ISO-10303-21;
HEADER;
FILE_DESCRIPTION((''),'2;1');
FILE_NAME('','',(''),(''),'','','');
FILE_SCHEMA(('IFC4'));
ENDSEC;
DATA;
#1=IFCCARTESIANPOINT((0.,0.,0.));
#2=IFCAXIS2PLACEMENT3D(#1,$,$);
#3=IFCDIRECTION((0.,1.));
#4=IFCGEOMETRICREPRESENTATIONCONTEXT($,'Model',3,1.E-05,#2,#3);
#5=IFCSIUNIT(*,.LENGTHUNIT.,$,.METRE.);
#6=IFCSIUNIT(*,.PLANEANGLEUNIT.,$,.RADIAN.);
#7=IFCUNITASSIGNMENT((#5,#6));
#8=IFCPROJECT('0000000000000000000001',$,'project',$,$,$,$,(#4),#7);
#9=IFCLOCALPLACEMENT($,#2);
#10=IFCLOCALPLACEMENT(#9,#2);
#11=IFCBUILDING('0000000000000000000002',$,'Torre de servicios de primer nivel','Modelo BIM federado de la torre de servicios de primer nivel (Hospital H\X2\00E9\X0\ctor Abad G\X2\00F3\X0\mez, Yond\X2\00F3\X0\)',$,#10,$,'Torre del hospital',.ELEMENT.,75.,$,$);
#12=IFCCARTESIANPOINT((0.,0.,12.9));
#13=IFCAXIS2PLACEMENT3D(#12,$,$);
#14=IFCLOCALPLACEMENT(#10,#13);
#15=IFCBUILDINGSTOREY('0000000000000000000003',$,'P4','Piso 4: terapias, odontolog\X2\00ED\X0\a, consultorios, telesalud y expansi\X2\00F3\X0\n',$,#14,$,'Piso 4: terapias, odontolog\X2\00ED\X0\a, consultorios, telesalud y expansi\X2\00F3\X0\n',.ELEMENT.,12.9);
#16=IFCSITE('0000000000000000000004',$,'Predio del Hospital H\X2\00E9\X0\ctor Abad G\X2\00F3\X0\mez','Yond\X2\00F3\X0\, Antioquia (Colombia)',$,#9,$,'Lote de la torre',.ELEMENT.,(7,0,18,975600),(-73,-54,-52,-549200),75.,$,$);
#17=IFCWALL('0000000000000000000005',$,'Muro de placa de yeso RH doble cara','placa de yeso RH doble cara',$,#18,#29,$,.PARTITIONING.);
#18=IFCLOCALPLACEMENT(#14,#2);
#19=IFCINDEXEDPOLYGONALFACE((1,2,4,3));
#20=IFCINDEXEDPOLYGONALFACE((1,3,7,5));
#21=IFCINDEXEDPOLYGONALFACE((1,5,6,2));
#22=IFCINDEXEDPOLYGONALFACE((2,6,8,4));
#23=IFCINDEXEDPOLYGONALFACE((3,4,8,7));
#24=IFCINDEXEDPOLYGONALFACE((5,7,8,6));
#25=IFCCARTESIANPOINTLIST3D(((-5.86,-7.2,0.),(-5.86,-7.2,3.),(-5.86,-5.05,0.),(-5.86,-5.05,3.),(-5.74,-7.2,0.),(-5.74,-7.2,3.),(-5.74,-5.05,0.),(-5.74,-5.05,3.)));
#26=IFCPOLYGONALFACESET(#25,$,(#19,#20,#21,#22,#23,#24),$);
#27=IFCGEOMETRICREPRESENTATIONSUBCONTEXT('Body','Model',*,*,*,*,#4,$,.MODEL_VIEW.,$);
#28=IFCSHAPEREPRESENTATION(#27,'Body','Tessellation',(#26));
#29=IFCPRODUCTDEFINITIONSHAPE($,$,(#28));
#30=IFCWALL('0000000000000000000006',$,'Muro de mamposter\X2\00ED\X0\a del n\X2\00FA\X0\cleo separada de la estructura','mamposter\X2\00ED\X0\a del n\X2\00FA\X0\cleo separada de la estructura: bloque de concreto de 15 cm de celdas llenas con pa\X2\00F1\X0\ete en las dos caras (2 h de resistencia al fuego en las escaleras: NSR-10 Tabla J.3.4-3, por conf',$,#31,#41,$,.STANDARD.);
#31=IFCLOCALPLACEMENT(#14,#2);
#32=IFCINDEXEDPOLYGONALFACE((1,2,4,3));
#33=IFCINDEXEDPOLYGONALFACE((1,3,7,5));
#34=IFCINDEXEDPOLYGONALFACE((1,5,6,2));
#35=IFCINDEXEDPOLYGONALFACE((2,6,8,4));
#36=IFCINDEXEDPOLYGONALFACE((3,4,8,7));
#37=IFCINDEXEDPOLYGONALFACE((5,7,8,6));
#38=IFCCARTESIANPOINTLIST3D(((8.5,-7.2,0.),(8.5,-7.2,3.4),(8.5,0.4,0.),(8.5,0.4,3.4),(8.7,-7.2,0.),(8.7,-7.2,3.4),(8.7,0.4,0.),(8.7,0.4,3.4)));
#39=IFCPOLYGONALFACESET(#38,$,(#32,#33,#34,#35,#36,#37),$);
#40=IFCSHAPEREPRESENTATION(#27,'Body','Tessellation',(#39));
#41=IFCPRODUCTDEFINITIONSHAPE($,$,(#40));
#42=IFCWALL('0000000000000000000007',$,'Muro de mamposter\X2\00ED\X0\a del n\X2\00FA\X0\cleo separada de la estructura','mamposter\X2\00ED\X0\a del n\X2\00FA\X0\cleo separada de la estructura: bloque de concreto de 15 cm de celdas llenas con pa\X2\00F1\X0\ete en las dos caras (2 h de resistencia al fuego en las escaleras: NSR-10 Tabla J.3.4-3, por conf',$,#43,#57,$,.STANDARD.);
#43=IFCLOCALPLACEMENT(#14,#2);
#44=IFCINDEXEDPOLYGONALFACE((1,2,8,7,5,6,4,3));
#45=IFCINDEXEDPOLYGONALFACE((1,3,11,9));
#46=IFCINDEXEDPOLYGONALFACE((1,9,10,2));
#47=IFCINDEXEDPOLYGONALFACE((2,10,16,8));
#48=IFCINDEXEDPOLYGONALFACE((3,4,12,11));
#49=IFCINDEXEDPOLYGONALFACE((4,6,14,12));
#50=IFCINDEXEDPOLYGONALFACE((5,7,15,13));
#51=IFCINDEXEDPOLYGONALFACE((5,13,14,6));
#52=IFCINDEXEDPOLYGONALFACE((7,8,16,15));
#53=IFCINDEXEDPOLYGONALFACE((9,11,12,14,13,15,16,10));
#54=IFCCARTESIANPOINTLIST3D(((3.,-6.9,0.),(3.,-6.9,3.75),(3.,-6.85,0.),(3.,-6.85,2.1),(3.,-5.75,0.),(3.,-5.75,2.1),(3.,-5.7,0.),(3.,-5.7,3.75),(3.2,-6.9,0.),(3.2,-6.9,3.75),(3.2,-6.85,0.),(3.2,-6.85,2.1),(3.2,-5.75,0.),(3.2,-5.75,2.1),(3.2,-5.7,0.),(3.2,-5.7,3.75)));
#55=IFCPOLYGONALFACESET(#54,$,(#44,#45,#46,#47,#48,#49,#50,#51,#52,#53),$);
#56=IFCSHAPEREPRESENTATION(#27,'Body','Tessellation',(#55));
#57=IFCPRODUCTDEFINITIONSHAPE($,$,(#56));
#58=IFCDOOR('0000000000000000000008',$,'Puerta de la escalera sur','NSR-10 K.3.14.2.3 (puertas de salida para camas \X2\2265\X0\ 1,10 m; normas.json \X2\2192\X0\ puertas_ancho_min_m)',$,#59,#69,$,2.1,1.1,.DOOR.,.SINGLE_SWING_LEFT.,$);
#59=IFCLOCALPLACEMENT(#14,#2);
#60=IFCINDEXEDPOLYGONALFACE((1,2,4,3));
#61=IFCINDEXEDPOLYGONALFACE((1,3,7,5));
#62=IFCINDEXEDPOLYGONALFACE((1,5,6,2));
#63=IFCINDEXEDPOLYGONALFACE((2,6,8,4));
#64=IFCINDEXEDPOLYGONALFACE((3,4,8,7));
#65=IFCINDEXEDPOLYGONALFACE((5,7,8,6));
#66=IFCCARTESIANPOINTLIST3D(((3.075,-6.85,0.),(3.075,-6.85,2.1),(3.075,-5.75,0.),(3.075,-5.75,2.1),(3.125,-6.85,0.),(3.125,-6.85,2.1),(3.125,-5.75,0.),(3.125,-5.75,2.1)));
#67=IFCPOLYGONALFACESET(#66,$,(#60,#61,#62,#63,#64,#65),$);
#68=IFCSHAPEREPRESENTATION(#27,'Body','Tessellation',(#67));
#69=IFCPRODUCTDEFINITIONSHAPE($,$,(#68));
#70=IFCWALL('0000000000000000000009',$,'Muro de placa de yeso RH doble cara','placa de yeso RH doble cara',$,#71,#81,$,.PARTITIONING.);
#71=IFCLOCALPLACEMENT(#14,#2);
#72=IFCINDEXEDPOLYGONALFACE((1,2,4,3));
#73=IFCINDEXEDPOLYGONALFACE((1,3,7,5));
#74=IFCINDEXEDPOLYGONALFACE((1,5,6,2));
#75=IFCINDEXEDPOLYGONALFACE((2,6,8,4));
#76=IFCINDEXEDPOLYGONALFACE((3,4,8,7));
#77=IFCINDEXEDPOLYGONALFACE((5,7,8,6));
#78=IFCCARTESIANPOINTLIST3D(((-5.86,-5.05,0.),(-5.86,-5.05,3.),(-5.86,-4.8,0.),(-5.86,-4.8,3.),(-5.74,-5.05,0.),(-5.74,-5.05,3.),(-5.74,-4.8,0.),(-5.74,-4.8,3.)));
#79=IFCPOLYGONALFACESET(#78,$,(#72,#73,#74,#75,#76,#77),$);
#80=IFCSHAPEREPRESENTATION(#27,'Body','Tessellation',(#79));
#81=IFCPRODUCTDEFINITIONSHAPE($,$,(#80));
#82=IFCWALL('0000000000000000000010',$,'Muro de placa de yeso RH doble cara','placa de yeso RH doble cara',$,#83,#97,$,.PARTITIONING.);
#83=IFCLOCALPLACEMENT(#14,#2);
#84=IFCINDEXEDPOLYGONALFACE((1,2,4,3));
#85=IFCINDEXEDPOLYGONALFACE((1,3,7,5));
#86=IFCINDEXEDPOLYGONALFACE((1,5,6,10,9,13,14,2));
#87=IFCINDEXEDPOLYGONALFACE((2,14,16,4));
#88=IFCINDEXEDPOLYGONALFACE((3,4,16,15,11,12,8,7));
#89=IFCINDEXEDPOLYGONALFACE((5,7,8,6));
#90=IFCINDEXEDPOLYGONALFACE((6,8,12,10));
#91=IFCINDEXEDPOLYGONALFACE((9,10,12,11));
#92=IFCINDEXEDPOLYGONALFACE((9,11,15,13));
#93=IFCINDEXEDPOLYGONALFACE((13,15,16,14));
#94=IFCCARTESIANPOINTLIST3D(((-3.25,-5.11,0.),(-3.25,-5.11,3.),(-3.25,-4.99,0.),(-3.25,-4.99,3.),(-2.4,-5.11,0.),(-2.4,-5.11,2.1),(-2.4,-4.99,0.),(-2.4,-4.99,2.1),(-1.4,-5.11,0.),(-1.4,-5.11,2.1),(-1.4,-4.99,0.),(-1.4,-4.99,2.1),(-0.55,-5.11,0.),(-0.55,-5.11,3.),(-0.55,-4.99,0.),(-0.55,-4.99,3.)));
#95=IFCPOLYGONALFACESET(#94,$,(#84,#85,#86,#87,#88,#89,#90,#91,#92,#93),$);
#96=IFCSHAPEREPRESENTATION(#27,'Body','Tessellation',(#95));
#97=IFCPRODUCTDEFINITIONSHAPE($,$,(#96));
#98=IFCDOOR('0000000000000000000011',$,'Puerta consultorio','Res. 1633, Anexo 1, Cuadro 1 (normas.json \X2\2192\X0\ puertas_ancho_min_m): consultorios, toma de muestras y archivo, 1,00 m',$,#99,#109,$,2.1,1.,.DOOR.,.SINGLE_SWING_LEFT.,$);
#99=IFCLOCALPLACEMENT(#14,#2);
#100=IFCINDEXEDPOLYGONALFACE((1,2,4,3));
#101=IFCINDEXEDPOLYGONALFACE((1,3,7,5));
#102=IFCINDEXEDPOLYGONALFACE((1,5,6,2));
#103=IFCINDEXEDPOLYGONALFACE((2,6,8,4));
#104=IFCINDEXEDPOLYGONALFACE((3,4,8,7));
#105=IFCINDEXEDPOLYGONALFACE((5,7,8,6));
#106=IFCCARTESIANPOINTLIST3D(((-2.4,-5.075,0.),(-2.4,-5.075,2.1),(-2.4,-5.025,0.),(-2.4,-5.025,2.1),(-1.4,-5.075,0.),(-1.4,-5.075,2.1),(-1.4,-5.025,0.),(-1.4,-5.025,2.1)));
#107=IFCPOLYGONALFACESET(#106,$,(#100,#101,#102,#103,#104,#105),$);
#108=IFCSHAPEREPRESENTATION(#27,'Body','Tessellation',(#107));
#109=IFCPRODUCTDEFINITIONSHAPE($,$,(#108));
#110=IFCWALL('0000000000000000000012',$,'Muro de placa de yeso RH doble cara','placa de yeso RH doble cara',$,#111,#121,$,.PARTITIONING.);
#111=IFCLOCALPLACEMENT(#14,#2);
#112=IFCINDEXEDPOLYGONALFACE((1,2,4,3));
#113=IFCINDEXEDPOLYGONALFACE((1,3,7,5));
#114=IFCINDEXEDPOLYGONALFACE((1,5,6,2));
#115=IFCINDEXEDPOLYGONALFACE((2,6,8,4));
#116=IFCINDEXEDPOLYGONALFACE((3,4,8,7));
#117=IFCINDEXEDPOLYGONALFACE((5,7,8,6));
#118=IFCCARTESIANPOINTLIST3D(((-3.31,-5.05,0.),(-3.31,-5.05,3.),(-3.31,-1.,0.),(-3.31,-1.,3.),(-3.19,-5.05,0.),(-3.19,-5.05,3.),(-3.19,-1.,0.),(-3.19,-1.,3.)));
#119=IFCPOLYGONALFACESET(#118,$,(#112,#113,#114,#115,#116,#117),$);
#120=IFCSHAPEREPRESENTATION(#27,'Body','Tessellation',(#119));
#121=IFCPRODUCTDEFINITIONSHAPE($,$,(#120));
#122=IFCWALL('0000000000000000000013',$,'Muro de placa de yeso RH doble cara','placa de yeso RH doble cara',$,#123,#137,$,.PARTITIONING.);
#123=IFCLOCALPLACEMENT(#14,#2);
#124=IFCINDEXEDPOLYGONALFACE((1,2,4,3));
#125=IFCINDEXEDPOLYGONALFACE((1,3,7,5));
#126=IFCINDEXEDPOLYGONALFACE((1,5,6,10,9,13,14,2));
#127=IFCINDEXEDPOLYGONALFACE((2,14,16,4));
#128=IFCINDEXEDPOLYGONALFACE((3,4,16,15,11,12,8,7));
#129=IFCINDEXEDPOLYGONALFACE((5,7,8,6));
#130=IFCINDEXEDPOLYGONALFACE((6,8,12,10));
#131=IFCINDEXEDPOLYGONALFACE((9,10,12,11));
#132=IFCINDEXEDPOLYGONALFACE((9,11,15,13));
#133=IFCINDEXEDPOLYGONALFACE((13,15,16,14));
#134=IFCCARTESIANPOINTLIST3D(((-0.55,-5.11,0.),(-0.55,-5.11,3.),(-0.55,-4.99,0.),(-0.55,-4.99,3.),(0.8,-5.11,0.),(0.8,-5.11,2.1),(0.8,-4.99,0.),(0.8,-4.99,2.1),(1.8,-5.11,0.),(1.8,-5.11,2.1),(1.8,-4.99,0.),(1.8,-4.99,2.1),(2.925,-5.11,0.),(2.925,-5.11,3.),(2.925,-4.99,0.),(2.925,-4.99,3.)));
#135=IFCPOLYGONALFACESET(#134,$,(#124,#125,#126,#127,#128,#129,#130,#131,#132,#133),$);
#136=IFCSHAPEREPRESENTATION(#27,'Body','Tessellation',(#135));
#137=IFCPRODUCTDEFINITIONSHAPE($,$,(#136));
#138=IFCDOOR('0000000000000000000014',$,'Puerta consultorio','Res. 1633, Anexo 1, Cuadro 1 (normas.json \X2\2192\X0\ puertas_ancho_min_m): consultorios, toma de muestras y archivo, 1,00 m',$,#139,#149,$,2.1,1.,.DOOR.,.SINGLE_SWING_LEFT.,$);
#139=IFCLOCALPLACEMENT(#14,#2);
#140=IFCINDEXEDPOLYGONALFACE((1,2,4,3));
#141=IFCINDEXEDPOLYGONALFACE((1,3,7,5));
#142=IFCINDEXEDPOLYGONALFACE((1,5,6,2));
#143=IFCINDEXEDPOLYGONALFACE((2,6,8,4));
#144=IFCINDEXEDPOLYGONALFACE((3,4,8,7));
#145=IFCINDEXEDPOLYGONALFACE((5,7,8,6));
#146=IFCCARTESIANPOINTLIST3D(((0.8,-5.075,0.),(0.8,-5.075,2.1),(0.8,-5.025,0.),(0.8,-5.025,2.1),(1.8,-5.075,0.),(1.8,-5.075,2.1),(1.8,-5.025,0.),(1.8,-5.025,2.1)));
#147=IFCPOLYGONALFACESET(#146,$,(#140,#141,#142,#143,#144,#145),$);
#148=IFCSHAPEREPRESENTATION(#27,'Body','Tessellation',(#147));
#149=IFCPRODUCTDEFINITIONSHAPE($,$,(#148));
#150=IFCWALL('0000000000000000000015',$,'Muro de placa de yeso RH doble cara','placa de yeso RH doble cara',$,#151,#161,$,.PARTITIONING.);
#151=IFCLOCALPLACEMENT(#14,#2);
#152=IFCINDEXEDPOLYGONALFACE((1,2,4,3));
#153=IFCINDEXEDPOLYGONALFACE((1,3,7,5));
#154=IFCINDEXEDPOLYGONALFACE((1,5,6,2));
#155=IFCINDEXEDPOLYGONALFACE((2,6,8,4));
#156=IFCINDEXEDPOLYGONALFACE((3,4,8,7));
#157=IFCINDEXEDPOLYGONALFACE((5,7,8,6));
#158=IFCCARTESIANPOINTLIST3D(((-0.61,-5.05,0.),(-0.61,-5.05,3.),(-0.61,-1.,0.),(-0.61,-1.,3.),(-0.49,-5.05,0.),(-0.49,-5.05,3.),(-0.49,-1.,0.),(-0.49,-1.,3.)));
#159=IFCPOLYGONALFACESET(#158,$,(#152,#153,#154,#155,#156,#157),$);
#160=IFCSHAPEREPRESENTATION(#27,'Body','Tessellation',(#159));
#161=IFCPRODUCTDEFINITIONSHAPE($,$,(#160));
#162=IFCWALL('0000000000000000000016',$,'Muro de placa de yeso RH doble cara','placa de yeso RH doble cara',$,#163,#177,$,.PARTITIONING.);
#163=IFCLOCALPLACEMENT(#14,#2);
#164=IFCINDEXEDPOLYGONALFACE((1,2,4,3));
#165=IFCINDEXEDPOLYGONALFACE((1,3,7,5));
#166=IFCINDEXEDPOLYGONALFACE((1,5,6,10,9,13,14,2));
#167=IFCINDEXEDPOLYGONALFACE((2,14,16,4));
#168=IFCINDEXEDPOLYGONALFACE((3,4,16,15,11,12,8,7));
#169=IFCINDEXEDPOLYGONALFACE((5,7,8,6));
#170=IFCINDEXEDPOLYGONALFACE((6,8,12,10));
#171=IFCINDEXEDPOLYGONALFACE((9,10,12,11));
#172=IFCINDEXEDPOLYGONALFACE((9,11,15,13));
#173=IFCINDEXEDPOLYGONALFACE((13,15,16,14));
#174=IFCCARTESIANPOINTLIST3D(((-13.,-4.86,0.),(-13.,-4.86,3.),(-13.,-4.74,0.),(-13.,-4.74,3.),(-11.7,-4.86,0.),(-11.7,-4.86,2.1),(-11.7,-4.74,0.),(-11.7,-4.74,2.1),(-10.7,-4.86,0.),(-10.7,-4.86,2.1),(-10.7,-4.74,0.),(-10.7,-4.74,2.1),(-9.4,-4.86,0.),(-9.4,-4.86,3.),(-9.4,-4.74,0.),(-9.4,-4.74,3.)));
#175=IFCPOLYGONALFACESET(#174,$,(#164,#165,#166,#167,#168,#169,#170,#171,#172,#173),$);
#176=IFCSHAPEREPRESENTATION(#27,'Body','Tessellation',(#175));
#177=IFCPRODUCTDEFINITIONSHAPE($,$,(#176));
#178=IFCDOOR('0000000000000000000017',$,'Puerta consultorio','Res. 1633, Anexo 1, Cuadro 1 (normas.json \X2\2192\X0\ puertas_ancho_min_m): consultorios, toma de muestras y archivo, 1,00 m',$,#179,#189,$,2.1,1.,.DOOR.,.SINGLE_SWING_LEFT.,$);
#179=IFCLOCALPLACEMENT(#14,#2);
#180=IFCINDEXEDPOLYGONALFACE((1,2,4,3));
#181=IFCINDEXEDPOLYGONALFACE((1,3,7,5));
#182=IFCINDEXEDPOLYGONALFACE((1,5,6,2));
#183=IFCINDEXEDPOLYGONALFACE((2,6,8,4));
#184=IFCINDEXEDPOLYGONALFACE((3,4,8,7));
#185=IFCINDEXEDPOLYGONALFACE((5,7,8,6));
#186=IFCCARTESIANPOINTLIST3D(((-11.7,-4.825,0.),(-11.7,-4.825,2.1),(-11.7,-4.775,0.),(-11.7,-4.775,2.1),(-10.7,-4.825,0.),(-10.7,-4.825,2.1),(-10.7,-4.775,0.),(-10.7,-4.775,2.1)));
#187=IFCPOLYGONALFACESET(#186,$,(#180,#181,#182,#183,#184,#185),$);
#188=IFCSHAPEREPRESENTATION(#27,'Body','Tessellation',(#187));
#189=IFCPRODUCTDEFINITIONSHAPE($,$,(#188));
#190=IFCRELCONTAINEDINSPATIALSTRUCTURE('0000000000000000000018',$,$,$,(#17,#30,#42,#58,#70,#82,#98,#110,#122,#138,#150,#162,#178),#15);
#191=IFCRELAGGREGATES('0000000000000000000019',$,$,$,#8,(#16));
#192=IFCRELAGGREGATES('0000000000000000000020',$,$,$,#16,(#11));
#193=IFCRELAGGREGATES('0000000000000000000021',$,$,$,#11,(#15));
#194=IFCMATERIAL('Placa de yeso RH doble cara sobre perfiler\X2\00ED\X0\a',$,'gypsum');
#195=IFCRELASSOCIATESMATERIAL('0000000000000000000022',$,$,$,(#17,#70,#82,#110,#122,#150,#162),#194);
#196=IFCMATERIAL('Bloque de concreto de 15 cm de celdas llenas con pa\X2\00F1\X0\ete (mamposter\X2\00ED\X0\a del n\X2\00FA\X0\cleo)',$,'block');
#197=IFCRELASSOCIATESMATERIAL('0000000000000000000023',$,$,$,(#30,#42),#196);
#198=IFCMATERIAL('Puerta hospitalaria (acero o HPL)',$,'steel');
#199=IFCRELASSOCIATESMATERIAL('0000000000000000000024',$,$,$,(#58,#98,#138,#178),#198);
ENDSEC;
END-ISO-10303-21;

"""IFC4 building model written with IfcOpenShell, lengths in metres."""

from ifc_helpers import new_model, si_unit, direction, frame, origin, place, context, subcontext, project, spatial, rectangle, extrude, material, element, fill, save


model = new_model("IFC4")

# Units and contexts
model_context = context("Model", 3, precision=1e-05, world=origin(), true_north=direction((0.0, 1.0)))
body_context = subcontext(model_context, "Body", "Model", "MODEL_VIEW")
ifc_project = project(units=[si_unit("LENGTHUNIT", "METRE"), si_unit("PLANEANGLEUNIT", "RADIAN")], contexts=[model_context])

# Site, building, storey
site_placement = place(None, origin())
site = spatial("IfcSite", under=ifc_project, at=site_placement, Name="Predio del Hospital Héctor Abad Gómez", Description="Yondó, Antioquia (Colombia)", LongName="Lote de la torre", CompositionType="ELEMENT", RefLatitude=(7, 0, 18, 975600), RefLongitude=(-73, -54, -52, -549200), RefElevation=75.0)
building_placement = place(site_placement, origin())
building = spatial("IfcBuilding", under=site, at=building_placement, Name="Torre de servicios de primer nivel", Description="Modelo BIM federado de la torre de servicios de primer nivel (Hospital Héctor Abad Gómez, Yondó)", LongName="Torre del hospital", CompositionType="ELEMENT", ElevationOfRefHeight=75.0)
placement = place(building_placement, frame((0.0, 0.0, 12.9)))
storey = spatial("IfcBuildingStorey", under=building, at=placement, Name="P4", Description="Piso 4: terapias, odontología, consultorios, telesalud y expansión", LongName="Piso 4: terapias, odontología, consultorios, telesalud y expansión", CompositionType="ELEMENT", Elevation=12.9)

# Walls
ifc_material_1 = material(Name="Placa de yeso RH doble cara sobre perfilería", Category="gypsum")
element("IfcWall", 1, at=placement, inside=storey, material=ifc_material_1, Name="Muro de placa de yeso RH doble cara", Description="placa de yeso RH doble cara", PredefinedType="PARTITIONING", context=body_context, shape_type="SweptSolid", body=[
    extrude(rectangle(XDim=0.12, YDim=2.15), frame((-5.8, -6.125, 0.0)), (0.0, 0.0, 1.0), 3.0),
])
ifc_material_2 = material(Name="Bloque de concreto de 15 cm de celdas llenas con pañete (mampostería del núcleo)", Category="block")
element("IfcWall", 2, at=placement, inside=storey, material=ifc_material_2, Name="Muro de mampostería del núcleo separada de la estructura", Description="mampostería del núcleo separada de la estructura: bloque de concreto de 15 cm de celdas llenas con pañete en las dos caras (2 h de resistencia al fuego en las escaleras: NSR-10 Tabla J.3.4-3, por conf", PredefinedType="STANDARD", context=body_context, shape_type="SweptSolid", body=[
    extrude(rectangle(XDim=0.2, YDim=7.6), frame((8.6, -3.4, 0.0)), (0.0, 0.0, 1.0), 3.4),
])

# Wall, opening, door
wall_1 = element("IfcWall", 3, at=placement, inside=storey, material=ifc_material_2, Name="Muro de mampostería del núcleo separada de la estructura", Description="mampostería del núcleo separada de la estructura: bloque de concreto de 15 cm de celdas llenas con pañete en las dos caras (2 h de resistencia al fuego en las escaleras: NSR-10 Tabla J.3.4-3, por conf", PredefinedType="STANDARD", context=body_context, shape_type="SweptSolid", body=[
    extrude(rectangle(XDim=0.2, YDim=1.2), frame((3.1, -6.3, 0.0)), (0.0, 0.0, 1.0), 3.75),
])
opening_1 = element("IfcOpeningElement", 4, at=placement, cuts=wall_1, PredefinedType="OPENING", context=body_context, shape_type="SweptSolid", body=[
    extrude(rectangle(XDim=0.3, YDim=1.1), frame((3.1, -6.3, 0.0)), (0.0, 0.0, 1.0), 2.1),
])
ifc_material_3 = material(Name="Puerta hospitalaria (acero o HPL)", Category="steel")
door_1 = element("IfcDoor", 5, at=placement, inside=storey, material=ifc_material_3, Name="Puerta de la escalera sur", Description="NSR-10 K.3.14.2.3 (puertas de salida para camas ≥ 1,10 m; normas.json → puertas_ancho_min_m)", OperationType="SINGLE_SWING_LEFT", OverallHeight=2.1, OverallWidth=1.1, PredefinedType="DOOR", context=body_context, shape_type="SweptSolid", body=[
    extrude(rectangle(XDim=0.05, YDim=1.1), frame((3.1, -6.3, 0.0)), (0.0, 0.0, 1.0), 2.1),
])
fill(opening_1, door_1)

# Wall
element("IfcWall", 6, at=placement, inside=storey, material=ifc_material_1, Name="Muro de placa de yeso RH doble cara", Description="placa de yeso RH doble cara", PredefinedType="PARTITIONING", context=body_context, shape_type="SweptSolid", body=[
    extrude(rectangle(XDim=0.12, YDim=0.25), frame((-5.8, -4.925, 0.0)), (0.0, 0.0, 1.0), 3.0),
])

# Wall, opening, door
wall_2 = element("IfcWall", 7, at=placement, inside=storey, material=ifc_material_1, Name="Muro de placa de yeso RH doble cara", Description="placa de yeso RH doble cara", PredefinedType="PARTITIONING", context=body_context, shape_type="SweptSolid", body=[
    extrude(rectangle(XDim=2.7, YDim=0.12), frame((-1.9, -5.05, 0.0)), (0.0, 0.0, 1.0), 3.0),
])
opening_2 = element("IfcOpeningElement", 8, at=placement, cuts=wall_2, PredefinedType="OPENING", context=body_context, shape_type="SweptSolid", body=[
    extrude(rectangle(XDim=1.0, YDim=0.22), frame((-1.9, -5.05, 0.0)), (0.0, 0.0, 1.0), 2.1),
])
door_2 = element("IfcDoor", 9, at=placement, inside=storey, material=ifc_material_3, Name="Puerta consultorio", Description="Res. 1633, Anexo 1, Cuadro 1 (normas.json → puertas_ancho_min_m): consultorios, toma de muestras y archivo, 1,00 m", OperationType="SINGLE_SWING_LEFT", OverallHeight=2.1, OverallWidth=1.0, PredefinedType="DOOR", context=body_context, shape_type="SweptSolid", body=[
    extrude(rectangle(XDim=1.0, YDim=0.05), frame((-1.9, -5.05, 0.0)), (0.0, 0.0, 1.0), 2.1),
])
fill(opening_2, door_2)

# Wall
element("IfcWall", 10, at=placement, inside=storey, material=ifc_material_1, Name="Muro de placa de yeso RH doble cara", Description="placa de yeso RH doble cara", PredefinedType="PARTITIONING", context=body_context, shape_type="SweptSolid", body=[
    extrude(rectangle(XDim=0.12, YDim=4.05), frame((-3.25, -3.025, 0.0)), (0.0, 0.0, 1.0), 3.0),
])

# Wall, opening, door
wall_3 = element("IfcWall", 11, at=placement, inside=storey, material=ifc_material_1, Name="Muro de placa de yeso RH doble cara", Description="placa de yeso RH doble cara", PredefinedType="PARTITIONING", context=body_context, shape_type="SweptSolid", body=[
    extrude(rectangle(XDim=3.475, YDim=0.12), frame((1.1875, -5.05, 0.0)), (0.0, 0.0, 1.0), 3.0),
])
opening_3 = element("IfcOpeningElement", 12, at=placement, cuts=wall_3, PredefinedType="OPENING", context=body_context, shape_type="SweptSolid", body=[
    extrude(rectangle(XDim=1.0, YDim=0.22), frame((1.3, -5.05, 0.0)), (0.0, 0.0, 1.0), 2.1),
])
door_3 = element("IfcDoor", 13, at=placement, inside=storey, material=ifc_material_3, Name="Puerta consultorio", Description="Res. 1633, Anexo 1, Cuadro 1 (normas.json → puertas_ancho_min_m): consultorios, toma de muestras y archivo, 1,00 m", OperationType="SINGLE_SWING_LEFT", OverallHeight=2.1, OverallWidth=1.0, PredefinedType="DOOR", context=body_context, shape_type="SweptSolid", body=[
    extrude(rectangle(XDim=1.0, YDim=0.05), frame((1.3, -5.05, 0.0)), (0.0, 0.0, 1.0), 2.1),
])
fill(opening_3, door_3)

# Wall
element("IfcWall", 14, at=placement, inside=storey, material=ifc_material_1, Name="Muro de placa de yeso RH doble cara", Description="placa de yeso RH doble cara", PredefinedType="PARTITIONING", context=body_context, shape_type="SweptSolid", body=[
    extrude(rectangle(XDim=0.12, YDim=4.05), frame((-0.55, -3.025, 0.0)), (0.0, 0.0, 1.0), 3.0),
])

# Wall, opening, door
wall_4 = element("IfcWall", 15, at=placement, inside=storey, material=ifc_material_1, Name="Muro de placa de yeso RH doble cara", Description="placa de yeso RH doble cara", PredefinedType="PARTITIONING", context=body_context, shape_type="SweptSolid", body=[
    extrude(rectangle(XDim=3.6, YDim=0.12), frame((-11.2, -4.8, 0.0)), (0.0, 0.0, 1.0), 3.0),
])
opening_4 = element("IfcOpeningElement", 16, at=placement, cuts=wall_4, PredefinedType="OPENING", context=body_context, shape_type="SweptSolid", body=[
    extrude(rectangle(XDim=1.0, YDim=0.22), frame((-11.2, -4.8, 0.0)), (0.0, 0.0, 1.0), 2.1),
])
door_4 = element("IfcDoor", 17, at=placement, inside=storey, material=ifc_material_3, Name="Puerta consultorio", Description="Res. 1633, Anexo 1, Cuadro 1 (normas.json → puertas_ancho_min_m): consultorios, toma de muestras y archivo, 1,00 m", OperationType="SINGLE_SWING_LEFT", OverallHeight=2.1, OverallWidth=1.0, PredefinedType="DOOR", context=body_context, shape_type="SweptSolid", body=[
    extrude(rectangle(XDim=1.0, YDim=0.05), frame((-11.2, -4.8, 0.0)), (0.0, 0.0, 1.0), 2.1),
])
fill(opening_4, door_4)

save(model, "model.ifc")
